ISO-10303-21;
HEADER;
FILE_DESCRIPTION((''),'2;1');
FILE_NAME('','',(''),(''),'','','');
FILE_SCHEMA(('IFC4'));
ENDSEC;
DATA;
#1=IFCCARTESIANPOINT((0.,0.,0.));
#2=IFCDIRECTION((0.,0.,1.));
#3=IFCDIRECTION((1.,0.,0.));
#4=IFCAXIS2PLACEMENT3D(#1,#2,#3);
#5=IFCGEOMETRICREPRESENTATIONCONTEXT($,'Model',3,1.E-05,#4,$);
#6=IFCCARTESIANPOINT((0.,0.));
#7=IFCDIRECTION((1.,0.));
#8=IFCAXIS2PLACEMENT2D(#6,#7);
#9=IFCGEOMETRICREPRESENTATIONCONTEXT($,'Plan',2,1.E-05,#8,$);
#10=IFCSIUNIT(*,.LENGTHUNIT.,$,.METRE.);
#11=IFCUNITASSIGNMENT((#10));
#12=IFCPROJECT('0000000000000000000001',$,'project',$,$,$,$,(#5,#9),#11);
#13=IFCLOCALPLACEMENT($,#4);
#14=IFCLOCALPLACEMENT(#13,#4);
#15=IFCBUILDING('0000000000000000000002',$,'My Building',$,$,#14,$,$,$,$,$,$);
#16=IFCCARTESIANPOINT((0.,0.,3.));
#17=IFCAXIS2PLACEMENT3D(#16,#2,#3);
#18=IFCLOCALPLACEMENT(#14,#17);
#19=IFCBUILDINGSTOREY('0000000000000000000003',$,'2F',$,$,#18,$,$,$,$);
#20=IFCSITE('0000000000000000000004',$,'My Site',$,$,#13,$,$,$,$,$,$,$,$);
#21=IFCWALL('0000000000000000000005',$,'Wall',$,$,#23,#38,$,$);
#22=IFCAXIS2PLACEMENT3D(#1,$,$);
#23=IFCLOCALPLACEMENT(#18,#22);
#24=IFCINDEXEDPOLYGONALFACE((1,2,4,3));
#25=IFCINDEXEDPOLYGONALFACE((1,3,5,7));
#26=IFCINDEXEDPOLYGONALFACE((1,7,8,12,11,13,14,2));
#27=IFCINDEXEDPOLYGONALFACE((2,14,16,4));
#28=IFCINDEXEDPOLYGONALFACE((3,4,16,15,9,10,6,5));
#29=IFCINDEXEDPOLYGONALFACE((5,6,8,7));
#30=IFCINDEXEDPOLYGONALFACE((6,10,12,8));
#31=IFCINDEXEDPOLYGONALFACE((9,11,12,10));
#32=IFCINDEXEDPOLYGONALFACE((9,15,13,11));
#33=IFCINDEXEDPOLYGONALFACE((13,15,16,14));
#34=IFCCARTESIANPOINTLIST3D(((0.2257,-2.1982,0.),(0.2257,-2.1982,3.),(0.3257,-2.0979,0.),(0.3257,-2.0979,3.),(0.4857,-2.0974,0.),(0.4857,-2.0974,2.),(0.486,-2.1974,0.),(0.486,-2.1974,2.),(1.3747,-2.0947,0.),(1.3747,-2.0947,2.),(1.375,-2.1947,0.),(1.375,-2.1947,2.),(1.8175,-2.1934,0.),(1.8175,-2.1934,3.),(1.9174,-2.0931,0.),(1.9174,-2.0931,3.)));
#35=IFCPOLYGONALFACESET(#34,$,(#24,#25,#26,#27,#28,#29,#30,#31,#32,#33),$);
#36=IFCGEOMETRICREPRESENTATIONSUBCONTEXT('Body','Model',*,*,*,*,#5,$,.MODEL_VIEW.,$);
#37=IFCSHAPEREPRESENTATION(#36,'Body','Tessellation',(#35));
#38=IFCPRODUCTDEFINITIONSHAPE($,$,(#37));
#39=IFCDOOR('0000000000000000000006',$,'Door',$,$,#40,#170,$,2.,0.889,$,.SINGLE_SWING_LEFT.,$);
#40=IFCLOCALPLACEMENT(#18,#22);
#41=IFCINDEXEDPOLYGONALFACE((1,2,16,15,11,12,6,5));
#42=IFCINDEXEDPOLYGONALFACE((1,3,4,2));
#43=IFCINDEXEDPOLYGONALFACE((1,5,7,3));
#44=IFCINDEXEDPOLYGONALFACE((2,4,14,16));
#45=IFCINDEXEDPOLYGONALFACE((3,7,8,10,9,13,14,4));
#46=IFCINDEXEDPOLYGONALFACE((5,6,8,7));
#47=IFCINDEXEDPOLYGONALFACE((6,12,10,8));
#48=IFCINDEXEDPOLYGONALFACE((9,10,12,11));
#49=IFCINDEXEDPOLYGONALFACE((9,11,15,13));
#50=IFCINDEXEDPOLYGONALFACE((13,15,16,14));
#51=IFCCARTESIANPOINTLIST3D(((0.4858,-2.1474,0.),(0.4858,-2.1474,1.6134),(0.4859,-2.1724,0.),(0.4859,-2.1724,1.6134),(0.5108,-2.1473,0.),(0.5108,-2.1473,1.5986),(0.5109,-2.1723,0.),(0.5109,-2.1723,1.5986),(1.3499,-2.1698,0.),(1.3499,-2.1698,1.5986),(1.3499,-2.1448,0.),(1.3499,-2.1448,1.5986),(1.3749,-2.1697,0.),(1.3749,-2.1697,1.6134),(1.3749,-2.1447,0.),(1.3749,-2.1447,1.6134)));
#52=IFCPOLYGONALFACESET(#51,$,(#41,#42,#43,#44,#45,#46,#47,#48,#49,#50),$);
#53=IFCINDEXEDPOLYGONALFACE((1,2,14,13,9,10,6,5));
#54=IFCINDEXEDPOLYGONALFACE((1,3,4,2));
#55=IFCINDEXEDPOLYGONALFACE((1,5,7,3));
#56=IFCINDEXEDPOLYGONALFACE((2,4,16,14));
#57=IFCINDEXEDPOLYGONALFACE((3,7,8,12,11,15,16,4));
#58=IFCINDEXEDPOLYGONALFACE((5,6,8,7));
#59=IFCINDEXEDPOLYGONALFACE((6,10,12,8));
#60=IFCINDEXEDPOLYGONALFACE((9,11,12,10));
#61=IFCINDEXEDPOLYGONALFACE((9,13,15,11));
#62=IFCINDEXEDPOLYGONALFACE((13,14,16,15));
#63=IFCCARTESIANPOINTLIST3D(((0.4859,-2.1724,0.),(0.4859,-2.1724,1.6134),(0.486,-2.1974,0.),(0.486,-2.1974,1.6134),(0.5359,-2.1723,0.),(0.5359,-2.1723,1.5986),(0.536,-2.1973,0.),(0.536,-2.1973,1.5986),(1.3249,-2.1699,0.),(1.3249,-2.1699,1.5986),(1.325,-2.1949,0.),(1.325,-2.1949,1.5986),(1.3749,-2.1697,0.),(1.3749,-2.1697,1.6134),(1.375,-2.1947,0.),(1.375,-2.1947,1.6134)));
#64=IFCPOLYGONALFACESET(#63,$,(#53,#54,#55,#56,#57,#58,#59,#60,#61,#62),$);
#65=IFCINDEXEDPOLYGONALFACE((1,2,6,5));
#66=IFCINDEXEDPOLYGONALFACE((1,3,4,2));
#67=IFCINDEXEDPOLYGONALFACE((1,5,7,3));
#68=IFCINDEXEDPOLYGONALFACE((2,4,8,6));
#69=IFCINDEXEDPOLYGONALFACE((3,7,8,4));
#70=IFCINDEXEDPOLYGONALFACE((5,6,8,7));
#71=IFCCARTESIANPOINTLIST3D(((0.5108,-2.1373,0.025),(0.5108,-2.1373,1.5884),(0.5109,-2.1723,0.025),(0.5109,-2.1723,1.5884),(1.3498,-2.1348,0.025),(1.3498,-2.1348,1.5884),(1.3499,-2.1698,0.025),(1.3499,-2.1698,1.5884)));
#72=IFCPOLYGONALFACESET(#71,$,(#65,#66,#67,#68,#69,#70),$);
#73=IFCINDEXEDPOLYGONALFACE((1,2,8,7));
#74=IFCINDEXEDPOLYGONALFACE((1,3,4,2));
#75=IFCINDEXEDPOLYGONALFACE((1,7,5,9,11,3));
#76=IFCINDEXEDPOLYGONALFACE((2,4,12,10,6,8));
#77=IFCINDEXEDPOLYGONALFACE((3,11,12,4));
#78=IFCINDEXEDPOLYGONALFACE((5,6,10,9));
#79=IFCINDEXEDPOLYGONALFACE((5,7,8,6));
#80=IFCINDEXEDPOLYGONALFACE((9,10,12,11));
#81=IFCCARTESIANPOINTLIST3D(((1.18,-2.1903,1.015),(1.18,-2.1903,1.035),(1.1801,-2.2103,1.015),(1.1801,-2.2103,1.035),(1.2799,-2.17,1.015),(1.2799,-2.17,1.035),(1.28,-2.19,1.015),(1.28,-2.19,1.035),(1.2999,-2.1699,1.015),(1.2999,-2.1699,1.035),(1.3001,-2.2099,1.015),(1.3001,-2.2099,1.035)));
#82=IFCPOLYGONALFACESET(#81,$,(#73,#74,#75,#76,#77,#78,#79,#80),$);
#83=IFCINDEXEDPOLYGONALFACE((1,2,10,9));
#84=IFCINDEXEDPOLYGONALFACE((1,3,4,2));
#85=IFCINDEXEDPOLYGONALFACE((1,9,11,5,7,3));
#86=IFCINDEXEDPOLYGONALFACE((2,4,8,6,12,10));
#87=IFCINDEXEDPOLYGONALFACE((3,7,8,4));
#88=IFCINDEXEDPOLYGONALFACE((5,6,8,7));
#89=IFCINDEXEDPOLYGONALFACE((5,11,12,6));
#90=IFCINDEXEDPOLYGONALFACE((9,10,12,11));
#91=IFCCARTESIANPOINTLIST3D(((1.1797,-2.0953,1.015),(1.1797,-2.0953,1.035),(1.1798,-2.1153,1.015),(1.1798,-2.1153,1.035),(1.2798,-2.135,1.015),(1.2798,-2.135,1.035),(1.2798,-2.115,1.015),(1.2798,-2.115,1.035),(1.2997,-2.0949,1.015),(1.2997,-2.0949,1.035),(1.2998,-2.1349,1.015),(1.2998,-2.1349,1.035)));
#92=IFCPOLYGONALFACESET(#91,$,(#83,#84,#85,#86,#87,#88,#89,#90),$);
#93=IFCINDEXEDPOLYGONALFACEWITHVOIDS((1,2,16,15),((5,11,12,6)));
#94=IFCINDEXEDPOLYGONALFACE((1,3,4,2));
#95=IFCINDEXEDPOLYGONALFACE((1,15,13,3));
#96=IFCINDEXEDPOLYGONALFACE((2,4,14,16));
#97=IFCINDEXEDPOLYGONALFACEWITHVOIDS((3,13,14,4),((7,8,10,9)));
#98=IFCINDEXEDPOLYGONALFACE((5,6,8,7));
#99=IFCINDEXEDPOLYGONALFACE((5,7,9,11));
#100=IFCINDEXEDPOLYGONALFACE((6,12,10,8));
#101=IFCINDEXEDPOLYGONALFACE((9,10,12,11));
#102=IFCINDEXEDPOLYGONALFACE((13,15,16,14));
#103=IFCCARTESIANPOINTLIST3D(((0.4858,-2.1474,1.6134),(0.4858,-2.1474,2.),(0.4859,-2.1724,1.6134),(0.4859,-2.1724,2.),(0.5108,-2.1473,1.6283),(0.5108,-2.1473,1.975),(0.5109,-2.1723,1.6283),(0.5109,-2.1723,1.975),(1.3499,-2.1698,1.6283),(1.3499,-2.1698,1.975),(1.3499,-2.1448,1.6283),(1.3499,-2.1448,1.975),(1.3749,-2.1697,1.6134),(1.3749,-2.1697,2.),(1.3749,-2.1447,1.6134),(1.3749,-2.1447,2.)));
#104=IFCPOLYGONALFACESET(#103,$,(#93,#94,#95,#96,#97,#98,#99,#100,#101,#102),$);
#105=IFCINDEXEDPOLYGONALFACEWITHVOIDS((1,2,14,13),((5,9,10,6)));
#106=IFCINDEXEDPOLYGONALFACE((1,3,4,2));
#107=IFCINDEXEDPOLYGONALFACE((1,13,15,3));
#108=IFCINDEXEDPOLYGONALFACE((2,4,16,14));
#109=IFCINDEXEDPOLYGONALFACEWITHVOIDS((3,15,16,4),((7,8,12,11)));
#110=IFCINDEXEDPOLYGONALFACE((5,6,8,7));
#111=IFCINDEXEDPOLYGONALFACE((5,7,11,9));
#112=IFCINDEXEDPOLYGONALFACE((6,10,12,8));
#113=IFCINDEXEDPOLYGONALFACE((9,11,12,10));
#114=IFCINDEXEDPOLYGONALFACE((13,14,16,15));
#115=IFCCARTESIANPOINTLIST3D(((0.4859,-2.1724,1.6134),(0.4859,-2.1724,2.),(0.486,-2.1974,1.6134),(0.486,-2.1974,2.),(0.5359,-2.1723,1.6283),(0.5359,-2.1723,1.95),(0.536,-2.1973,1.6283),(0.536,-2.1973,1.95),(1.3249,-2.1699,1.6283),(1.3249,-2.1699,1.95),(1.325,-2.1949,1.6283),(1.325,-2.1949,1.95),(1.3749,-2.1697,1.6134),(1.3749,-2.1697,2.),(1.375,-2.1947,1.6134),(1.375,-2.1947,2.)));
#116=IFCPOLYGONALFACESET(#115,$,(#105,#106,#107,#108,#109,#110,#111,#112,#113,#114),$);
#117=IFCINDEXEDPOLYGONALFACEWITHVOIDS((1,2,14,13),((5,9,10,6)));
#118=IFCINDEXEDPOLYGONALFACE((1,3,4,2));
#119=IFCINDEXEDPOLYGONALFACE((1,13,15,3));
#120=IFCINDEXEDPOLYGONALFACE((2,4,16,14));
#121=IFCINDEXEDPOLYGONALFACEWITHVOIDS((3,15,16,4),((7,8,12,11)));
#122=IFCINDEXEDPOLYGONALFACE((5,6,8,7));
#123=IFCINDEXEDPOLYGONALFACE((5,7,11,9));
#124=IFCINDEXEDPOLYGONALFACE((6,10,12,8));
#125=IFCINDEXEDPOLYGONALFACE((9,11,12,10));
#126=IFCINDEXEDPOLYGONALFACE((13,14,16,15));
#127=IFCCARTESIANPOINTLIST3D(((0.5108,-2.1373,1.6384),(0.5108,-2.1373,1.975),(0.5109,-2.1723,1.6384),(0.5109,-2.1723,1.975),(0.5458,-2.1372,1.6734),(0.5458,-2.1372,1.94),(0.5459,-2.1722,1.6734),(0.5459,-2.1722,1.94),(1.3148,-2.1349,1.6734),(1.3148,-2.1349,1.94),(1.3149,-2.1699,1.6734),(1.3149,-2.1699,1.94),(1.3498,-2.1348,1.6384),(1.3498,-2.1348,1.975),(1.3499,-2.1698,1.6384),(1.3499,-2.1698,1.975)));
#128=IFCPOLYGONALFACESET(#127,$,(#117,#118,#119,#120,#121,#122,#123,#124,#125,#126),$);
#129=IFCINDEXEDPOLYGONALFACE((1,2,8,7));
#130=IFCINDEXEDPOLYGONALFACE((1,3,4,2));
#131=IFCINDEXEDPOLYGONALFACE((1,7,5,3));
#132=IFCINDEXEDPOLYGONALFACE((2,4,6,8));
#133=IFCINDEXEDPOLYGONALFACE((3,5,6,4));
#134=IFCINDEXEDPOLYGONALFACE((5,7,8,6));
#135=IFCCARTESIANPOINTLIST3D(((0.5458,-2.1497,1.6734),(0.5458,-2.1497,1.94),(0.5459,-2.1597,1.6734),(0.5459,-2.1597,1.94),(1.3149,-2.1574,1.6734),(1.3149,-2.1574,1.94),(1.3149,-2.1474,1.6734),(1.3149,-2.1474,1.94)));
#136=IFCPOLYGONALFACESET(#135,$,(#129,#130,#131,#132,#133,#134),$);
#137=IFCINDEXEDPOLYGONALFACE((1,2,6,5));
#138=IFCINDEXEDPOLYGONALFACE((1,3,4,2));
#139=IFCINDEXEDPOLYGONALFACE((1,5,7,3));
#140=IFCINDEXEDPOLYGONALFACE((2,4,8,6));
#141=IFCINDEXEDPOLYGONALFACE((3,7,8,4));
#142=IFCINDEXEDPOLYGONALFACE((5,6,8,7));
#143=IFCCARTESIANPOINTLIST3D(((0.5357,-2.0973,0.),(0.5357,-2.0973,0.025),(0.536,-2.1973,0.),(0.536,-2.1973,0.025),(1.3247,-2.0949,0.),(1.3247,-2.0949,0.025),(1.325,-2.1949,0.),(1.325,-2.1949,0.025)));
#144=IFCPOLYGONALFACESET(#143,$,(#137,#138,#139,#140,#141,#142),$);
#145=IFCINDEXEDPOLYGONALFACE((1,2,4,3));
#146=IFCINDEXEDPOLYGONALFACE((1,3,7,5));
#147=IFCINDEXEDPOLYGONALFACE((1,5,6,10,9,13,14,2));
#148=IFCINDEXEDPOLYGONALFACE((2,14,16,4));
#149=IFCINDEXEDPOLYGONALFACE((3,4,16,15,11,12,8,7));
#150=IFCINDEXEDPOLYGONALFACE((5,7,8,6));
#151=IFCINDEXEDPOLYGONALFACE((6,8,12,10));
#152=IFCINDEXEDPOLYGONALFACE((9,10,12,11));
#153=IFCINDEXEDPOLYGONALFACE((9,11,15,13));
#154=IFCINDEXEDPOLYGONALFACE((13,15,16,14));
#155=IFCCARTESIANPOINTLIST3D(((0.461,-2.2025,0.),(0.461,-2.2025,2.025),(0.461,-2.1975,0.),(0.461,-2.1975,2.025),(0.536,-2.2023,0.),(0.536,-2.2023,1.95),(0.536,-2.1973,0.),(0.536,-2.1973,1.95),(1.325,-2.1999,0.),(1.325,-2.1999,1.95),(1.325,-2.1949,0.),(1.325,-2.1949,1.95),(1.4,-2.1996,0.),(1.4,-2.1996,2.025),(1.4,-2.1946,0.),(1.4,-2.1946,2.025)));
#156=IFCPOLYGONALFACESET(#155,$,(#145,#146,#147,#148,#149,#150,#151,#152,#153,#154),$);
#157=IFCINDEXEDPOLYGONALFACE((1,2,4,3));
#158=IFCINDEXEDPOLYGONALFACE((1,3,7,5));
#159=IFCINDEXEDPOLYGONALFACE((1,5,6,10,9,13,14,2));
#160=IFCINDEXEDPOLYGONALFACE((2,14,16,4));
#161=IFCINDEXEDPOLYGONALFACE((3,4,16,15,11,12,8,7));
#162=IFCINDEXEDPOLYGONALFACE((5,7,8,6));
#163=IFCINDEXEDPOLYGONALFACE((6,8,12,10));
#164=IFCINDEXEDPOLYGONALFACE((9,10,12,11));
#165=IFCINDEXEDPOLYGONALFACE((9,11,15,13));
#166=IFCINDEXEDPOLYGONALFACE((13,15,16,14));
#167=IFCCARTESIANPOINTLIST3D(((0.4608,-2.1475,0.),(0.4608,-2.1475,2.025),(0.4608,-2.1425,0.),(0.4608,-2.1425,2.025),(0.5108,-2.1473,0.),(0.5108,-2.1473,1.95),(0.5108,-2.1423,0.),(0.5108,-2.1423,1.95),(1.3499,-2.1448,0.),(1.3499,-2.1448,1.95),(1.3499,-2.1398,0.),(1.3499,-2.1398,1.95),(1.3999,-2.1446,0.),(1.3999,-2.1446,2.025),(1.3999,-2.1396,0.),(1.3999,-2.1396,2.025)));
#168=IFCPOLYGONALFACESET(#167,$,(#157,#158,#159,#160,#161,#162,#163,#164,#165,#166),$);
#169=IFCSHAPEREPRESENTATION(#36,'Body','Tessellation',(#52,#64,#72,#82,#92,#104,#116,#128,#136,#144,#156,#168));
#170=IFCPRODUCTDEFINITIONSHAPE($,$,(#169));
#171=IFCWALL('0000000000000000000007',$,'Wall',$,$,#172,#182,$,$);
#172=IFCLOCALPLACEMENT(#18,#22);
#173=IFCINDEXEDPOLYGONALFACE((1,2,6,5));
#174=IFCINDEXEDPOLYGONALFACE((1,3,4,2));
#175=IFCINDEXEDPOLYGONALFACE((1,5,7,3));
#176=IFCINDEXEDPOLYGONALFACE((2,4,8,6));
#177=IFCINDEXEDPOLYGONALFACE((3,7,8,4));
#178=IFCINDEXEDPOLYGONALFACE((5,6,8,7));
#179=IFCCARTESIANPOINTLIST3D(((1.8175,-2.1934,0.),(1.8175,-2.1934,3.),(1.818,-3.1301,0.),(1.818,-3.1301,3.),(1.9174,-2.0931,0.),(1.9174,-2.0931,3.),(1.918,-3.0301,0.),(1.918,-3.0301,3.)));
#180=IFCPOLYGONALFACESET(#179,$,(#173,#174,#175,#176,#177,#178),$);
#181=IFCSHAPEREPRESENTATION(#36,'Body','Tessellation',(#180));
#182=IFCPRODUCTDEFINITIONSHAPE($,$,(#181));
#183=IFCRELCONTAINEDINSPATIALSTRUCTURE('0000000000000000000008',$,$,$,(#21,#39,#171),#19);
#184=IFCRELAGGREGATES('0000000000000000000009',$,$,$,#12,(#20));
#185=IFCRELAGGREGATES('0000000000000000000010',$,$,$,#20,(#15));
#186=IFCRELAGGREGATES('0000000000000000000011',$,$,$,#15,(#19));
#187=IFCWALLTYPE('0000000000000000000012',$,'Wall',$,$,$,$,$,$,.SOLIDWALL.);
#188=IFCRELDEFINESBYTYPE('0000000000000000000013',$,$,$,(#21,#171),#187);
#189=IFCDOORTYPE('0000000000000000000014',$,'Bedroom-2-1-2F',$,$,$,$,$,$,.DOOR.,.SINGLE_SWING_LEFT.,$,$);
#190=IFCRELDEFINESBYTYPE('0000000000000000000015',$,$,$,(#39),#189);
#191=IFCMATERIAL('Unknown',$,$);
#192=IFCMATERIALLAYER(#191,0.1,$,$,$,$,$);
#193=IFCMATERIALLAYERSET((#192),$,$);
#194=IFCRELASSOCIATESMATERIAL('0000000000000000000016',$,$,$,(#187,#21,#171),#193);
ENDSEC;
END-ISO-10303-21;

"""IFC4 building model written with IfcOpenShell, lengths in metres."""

from ifc_helpers import new_model, entity, si_unit, frame, origin_with_axes, origin_2d_with_axis, place, context, subcontext, project, spatial, line, indexed_curve, outline, extrude, shape, source, transform, mapped, material, layer, layer_set, layer_usage, type_object, type_shapes, element, fill, save


model = new_model("IFC4")

# Units and contexts
model_context = context("Model", 3, precision=1e-05, world=origin_with_axes())
plan_context = context("Plan", 2, precision=1e-05, world=origin_2d_with_axis())
body_context_1 = subcontext(model_context, "Body", "Model", "MODEL_VIEW")
body_context_2 = subcontext(plan_context, "Body", "Plan", "PLAN_VIEW")
ifc_project = project(units=[si_unit("LENGTHUNIT", "METRE")], contexts=[model_context, plan_context])

# Site, building, storey
site_placement = place(None, origin_with_axes())
site = spatial("IfcSite", under=ifc_project, at=site_placement, Name="My Site")
building_placement = place(site_placement, origin_with_axes())
building = spatial("IfcBuilding", under=site, at=building_placement, Name="My Building")
storey_placement = place(building_placement, frame((0.0, 0.0, 3.0), z_axis=(0.0, 0.0, 1.0), x_axis=(1.0, 0.0, 0.0)))
storey = spatial("IfcBuildingStorey", under=building, at=storey_placement, Name="2F")

# Shared definitions
ifc_material = material(Name="Unknown")
ifc_layer = layer(ifc_material, 0.1)
ifc_layer_set = layer_set([ifc_layer])
wall_type = type_object("IfcWallType", Name="Wall", PredefinedType="SOLIDWALL", material=ifc_layer_set)

# Wall, opening, door
ifc_layer_usage_1 = layer_usage(ifc_layer_set, "AXIS2", "POSITIVE", 0.0)
wall_1_placement = place(storey_placement, frame((0.2257, -2.1982, 0.0), z_axis=(0.0, 0.0, 1.0), x_axis=(0.999995, 0.003047, 0.0)))
wall_1 = element("IfcWall", 1, at=wall_1_placement, inside=storey, type_object=wall_type, material=ifc_layer_usage_1, Name="Wall", context=body_context_1, shape_type="SweptSolid", body=[
    extrude(outline(indexed_curve([(0.0, 0.0), (0.1003, 0.1), (1.692, 0.1), (1.5917, 0.0)], segments=[line(1, 2, 3, 4, 1)])), origin_with_axes(), (0.0, 0.0, 1.0), 3.0),
])
shared_shape_1 = source(origin_with_axes(), body_context_1, "Body", "SweptSolid", [
    extrude(outline(indexed_curve([(0.0, 0.0), (0.889, 0.0), (0.889, 2.0), (0.0, 2.0)], segments=[line(1, 2, 3, 4, 1)])), frame((0.0, -0.6, 0.0), z_axis=(0.0, -1.0, 0.0), x_axis=(1.0, 0.0, 0.0)), (0.0, 0.0, -1.0), 1.2),
])
opening_1_placement = place(wall_1_placement, frame((0.2603, 0.0, 0.0), z_axis=(0.0, 0.0, 1.0), x_axis=(1.0, 0.0, 0.0)))
opening_1 = element("IfcOpeningElement", 2, at=opening_1_placement, cuts=wall_1, PredefinedType="OPENING", context=body_context_1, shape_type="MappedRepresentation", body=[
    mapped(shared_shape_1, transform((0.0, 0.0, 0.0), x_axis=(1.0, 0.0, 0.0), y_axis=(0.0, 1.0, 0.0), z_axis=(0.0, 0.0, 1.0), scale=1.0)),
])
door_type_1 = type_object("IfcDoorType", Name="Bedroom-2-1-2F", OperationType="SINGLE_SWING_LEFT", PredefinedType="DOOR")
shared_shape_2 = source(origin_with_axes(), body_context_1, "Body", "SweptSolid", [
    extrude(outline(indexed_curve([(0.0, 0.0), (0.0, 1.6134), (0.889, 1.6134), (0.889, 0.0), (0.864, 0.0), (0.864, 1.5986), (0.025, 1.5986), (0.025, 0.0)], segments=[line(1, 2, 3, 4, 5, 6, 7, 8, 1)])), frame((0.0, 0.025, 0.0), z_axis=(0.0, -1.0, 0.0), x_axis=(1.0, 0.0, 0.0)), (0.0, 0.0, -1.0), 0.025),
    extrude(outline(indexed_curve([(0.0, 0.0), (0.0, 1.6134), (0.889, 1.6134), (0.889, 0.0), (0.839, 0.0), (0.839, 1.5986), (0.05, 1.5986), (0.05, 0.0)], segments=[line(1, 2, 3, 4, 5, 6, 7, 8, 1)])), frame((0.0, 0.0, 0.0), z_axis=(0.0, -1.0, 0.0), x_axis=(1.0, 0.0, 0.0)), (0.0, 0.0, -1.0), 0.025),
    extrude(outline(indexed_curve([(0.0, 0.0), (0.839, 0.0), (0.839, 0.035), (0.0, 0.035)], segments=[line(1, 2, 3, 4, 1)])), frame((0.025, 0.025, 0.025), z_axis=(0.0, 0.0, 1.0), x_axis=(1.0, 0.0, 0.0)), (0.0, 0.0, 1.0), 1.5634),
    extrude(outline(indexed_curve([(0.0, 0.0), (0.0, -0.04), (-0.12, -0.04), (-0.12, -0.02), (-0.02, -0.02), (-0.02, 0.0)], segments=[line(1, 2, 3, 4, 5, 6, 1)])), frame((0.814, 0.025, 1.015), z_axis=(0.0, 0.0, 1.0), x_axis=(1.0, 0.0, 0.0)), (0.0, 0.0, 1.0), 0.02),
    extrude(outline(indexed_curve([(0.0, 0.0), (0.0, 0.04), (-0.12, 0.04), (-0.12, 0.02), (-0.02, 0.02), (-0.02, 0.0)], segments=[line(1, 2, 3, 4, 5, 6, 1)])), frame((0.814, 0.06, 1.015), z_axis=(0.0, 0.0, 1.0), x_axis=(1.0, 0.0, 0.0)), (0.0, 0.0, 1.0), 0.02),
    extrude(outline(indexed_curve([(0.0, 0.0), (0.889, 0.0), (0.889, 0.3866), (0.0, 0.3866)], segments=[line(1, 2, 3, 4, 1)]), holes=[indexed_curve([(0.025, 0.0148), (0.864, 0.0148), (0.864, 0.3616), (0.025, 0.3616)], segments=[line(1, 2, 3, 4, 1)])]), frame((0.0, 0.025, 1.6134), z_axis=(0.0, -1.0, 0.0), x_axis=(1.0, 0.0, 0.0)), (0.0, 0.0, -1.0), 0.025),
    extrude(outline(indexed_curve([(0.0, 0.0), (0.889, 0.0), (0.889, 0.3866), (0.0, 0.3866)], segments=[line(1, 2, 3, 4, 1)]), holes=[indexed_curve([(0.05, 0.0148), (0.839, 0.0148), (0.839, 0.3366), (0.05, 0.3366)], segments=[line(1, 2, 3, 4, 1)])]), frame((0.0, 0.0, 1.6134), z_axis=(0.0, -1.0, 0.0), x_axis=(1.0, 0.0, 0.0)), (0.0, 0.0, -1.0), 0.025),
    extrude(outline(indexed_curve([(0.0, 0.0), (0.839, 0.0), (0.839, 0.3366), (0.0, 0.3366)], segments=[line(1, 2, 3, 4, 1)]), holes=[indexed_curve([(0.035, 0.035), (0.804, 0.035), (0.804, 0.3016), (0.035, 0.3016)], segments=[line(1, 2, 3, 4, 1)])]), frame((0.025, 0.025, 1.6384), z_axis=(0.0, -1.0, 0.0), x_axis=(1.0, 0.0, 0.0)), (0.0, 0.0, -1.0), 0.035),
    extrude(outline(indexed_curve([(0.035, 0.035), (0.804, 0.035), (0.804, 0.3016), (0.035, 0.3016)], segments=[line(1, 2, 3, 4, 1)])), frame((0.025, 0.0375, 1.6384), z_axis=(0.0, -1.0, 0.0), x_axis=(1.0, 0.0, 0.0)), (0.0, 0.0, -1.0), 0.01),
    extrude(outline(indexed_curve([(0.0, 0.0), (0.789, 0.0), (0.789, 0.1), (0.0, 0.1)], segments=[line(1, 2, 3, 4, 1)])), frame((0.05, 0.0, 0.0), z_axis=(0.0, 0.0, 1.0), x_axis=(1.0, 0.0, 0.0)), (0.0, 0.0, 1.0), 0.025),
    extrude(outline(indexed_curve([(0.0, 0.0), (0.0, 2.025), (0.939, 2.025), (0.939, 0.0), (0.864, 0.0), (0.864, 1.95), (0.075, 1.95), (0.075, 0.0)], segments=[line(1, 2, 3, 4, 5, 6, 7, 8, 1)])), frame((-0.025, -0.005, 0.0), z_axis=(0.0, -1.0, 0.0), x_axis=(1.0, 0.0, 0.0)), (0.0, 0.0, -1.0), 0.005),
    extrude(outline(indexed_curve([(0.0, 0.0), (0.0, 2.025), (0.939, 2.025), (0.939, 0.0), (0.889, 0.0), (0.889, 1.95), (0.05, 1.95), (0.05, 0.0)], segments=[line(1, 2, 3, 4, 5, 6, 7, 8, 1)])), frame((-0.025, 0.05, 0.0), z_axis=(0.0, -1.0, 0.0), x_axis=(1.0, 0.0, 0.0)), (0.0, 0.0, -1.0), 0.005),
])
shared_shape_3 = source(origin_with_axes(), body_context_2, "Body", "Curve2D", [
    entity("IfcIndexedPolyCurve", entity("IfcCartesianPointList2D", [[0.0, 0.0], [0.0, 0.05], [0.025, 0.05], [0.025, 0.025], [0.05, 0.025], [0.05, 0.0]]), [entity("IfcLineIndex", [1, 2, 3, 4, 5, 6, 1])]),
    entity("IfcIndexedPolyCurve", entity("IfcCartesianPointList2D", [[0.889, 0.0], [0.889, 0.05], [0.864, 0.05], [0.864, 0.025], [0.839, 0.025], [0.839, 0.0]]), [entity("IfcLineIndex", [1, 2, 3, 4, 5, 6, 1])]),
    entity("IfcTrimmedCurve", entity("IfcEllipse", entity("IfcAxis2Placement2D", entity("IfcCartesianPoint", [0.06, 0.05]), entity("IfcDirection", [1.0, 0.0])), 0.804, 0.839), [entity("IfcCartesianPoint", [0.864, 0.05])], [entity("IfcCartesianPoint", [0.06, 0.889])], True, "CARTESIAN"),
    entity("IfcIndexedPolyCurve", entity("IfcCartesianPointList2D", [[0.025, 0.05], [0.06, 0.05], [0.06, 0.889], [0.025, 0.889]]), [entity("IfcLineIndex", [1, 2, 3, 4, 1])]),
])
type_shapes(door_type_1, [shared_shape_2, shared_shape_3])
door_1_placement = place(opening_1_placement, frame((0.0, 0.0, 0.0), z_axis=(0.0, 0.0, 1.0), x_axis=(1.0, 0.0, 0.0)))
door_1 = element("IfcDoor", 3, at=door_1_placement, inside=storey, type_object=door_type_1, Name="Door", OperationType="SINGLE_SWING_LEFT", OverallHeight=2.0, OverallWidth=0.889, shapes=[
    shape(body_context_1, "Body", "MappedRepresentation", [mapped(shared_shape_2, transform((0.0, 0.0, 0.0), x_axis=(1.0, 0.0, 0.0), y_axis=(0.0, 1.0, 0.0), z_axis=(0.0, 0.0, 1.0), scale=1.0))]),
    shape(body_context_2, "Body", "MappedRepresentation", [mapped(shared_shape_3, transform((0.0, 0.0, 0.0), x_axis=(1.0, 0.0, 0.0), y_axis=(0.0, 1.0, 0.0), z_axis=(0.0, 0.0, 1.0), scale=1.0))]),
])
fill(opening_1, door_1)

# Wall
ifc_layer_usage_2 = layer_usage(ifc_layer_set, "AXIS2", "POSITIVE", 0.0)
wall_2_placement = place(storey_placement, frame((1.8175, -2.1934, 0.0), z_axis=(0.0, 0.0, 1.0), x_axis=(0.000608, -1.0, 0.0)))
element("IfcWall", 4, at=wall_2_placement, inside=storey, type_object=wall_type, material=ifc_layer_usage_2, Name="Wall", context=body_context_1, shape_type="SweptSolid", body=[
    extrude(outline(indexed_curve([(0.0, 0.0), (-0.1002, 0.1), (0.8368, 0.1), (0.9368, 0.0)], segments=[line(1, 2, 3, 4, 1)])), origin_with_axes(), (0.0, 0.0, 1.0), 3.0),
])

save(model, "model.ifc")
